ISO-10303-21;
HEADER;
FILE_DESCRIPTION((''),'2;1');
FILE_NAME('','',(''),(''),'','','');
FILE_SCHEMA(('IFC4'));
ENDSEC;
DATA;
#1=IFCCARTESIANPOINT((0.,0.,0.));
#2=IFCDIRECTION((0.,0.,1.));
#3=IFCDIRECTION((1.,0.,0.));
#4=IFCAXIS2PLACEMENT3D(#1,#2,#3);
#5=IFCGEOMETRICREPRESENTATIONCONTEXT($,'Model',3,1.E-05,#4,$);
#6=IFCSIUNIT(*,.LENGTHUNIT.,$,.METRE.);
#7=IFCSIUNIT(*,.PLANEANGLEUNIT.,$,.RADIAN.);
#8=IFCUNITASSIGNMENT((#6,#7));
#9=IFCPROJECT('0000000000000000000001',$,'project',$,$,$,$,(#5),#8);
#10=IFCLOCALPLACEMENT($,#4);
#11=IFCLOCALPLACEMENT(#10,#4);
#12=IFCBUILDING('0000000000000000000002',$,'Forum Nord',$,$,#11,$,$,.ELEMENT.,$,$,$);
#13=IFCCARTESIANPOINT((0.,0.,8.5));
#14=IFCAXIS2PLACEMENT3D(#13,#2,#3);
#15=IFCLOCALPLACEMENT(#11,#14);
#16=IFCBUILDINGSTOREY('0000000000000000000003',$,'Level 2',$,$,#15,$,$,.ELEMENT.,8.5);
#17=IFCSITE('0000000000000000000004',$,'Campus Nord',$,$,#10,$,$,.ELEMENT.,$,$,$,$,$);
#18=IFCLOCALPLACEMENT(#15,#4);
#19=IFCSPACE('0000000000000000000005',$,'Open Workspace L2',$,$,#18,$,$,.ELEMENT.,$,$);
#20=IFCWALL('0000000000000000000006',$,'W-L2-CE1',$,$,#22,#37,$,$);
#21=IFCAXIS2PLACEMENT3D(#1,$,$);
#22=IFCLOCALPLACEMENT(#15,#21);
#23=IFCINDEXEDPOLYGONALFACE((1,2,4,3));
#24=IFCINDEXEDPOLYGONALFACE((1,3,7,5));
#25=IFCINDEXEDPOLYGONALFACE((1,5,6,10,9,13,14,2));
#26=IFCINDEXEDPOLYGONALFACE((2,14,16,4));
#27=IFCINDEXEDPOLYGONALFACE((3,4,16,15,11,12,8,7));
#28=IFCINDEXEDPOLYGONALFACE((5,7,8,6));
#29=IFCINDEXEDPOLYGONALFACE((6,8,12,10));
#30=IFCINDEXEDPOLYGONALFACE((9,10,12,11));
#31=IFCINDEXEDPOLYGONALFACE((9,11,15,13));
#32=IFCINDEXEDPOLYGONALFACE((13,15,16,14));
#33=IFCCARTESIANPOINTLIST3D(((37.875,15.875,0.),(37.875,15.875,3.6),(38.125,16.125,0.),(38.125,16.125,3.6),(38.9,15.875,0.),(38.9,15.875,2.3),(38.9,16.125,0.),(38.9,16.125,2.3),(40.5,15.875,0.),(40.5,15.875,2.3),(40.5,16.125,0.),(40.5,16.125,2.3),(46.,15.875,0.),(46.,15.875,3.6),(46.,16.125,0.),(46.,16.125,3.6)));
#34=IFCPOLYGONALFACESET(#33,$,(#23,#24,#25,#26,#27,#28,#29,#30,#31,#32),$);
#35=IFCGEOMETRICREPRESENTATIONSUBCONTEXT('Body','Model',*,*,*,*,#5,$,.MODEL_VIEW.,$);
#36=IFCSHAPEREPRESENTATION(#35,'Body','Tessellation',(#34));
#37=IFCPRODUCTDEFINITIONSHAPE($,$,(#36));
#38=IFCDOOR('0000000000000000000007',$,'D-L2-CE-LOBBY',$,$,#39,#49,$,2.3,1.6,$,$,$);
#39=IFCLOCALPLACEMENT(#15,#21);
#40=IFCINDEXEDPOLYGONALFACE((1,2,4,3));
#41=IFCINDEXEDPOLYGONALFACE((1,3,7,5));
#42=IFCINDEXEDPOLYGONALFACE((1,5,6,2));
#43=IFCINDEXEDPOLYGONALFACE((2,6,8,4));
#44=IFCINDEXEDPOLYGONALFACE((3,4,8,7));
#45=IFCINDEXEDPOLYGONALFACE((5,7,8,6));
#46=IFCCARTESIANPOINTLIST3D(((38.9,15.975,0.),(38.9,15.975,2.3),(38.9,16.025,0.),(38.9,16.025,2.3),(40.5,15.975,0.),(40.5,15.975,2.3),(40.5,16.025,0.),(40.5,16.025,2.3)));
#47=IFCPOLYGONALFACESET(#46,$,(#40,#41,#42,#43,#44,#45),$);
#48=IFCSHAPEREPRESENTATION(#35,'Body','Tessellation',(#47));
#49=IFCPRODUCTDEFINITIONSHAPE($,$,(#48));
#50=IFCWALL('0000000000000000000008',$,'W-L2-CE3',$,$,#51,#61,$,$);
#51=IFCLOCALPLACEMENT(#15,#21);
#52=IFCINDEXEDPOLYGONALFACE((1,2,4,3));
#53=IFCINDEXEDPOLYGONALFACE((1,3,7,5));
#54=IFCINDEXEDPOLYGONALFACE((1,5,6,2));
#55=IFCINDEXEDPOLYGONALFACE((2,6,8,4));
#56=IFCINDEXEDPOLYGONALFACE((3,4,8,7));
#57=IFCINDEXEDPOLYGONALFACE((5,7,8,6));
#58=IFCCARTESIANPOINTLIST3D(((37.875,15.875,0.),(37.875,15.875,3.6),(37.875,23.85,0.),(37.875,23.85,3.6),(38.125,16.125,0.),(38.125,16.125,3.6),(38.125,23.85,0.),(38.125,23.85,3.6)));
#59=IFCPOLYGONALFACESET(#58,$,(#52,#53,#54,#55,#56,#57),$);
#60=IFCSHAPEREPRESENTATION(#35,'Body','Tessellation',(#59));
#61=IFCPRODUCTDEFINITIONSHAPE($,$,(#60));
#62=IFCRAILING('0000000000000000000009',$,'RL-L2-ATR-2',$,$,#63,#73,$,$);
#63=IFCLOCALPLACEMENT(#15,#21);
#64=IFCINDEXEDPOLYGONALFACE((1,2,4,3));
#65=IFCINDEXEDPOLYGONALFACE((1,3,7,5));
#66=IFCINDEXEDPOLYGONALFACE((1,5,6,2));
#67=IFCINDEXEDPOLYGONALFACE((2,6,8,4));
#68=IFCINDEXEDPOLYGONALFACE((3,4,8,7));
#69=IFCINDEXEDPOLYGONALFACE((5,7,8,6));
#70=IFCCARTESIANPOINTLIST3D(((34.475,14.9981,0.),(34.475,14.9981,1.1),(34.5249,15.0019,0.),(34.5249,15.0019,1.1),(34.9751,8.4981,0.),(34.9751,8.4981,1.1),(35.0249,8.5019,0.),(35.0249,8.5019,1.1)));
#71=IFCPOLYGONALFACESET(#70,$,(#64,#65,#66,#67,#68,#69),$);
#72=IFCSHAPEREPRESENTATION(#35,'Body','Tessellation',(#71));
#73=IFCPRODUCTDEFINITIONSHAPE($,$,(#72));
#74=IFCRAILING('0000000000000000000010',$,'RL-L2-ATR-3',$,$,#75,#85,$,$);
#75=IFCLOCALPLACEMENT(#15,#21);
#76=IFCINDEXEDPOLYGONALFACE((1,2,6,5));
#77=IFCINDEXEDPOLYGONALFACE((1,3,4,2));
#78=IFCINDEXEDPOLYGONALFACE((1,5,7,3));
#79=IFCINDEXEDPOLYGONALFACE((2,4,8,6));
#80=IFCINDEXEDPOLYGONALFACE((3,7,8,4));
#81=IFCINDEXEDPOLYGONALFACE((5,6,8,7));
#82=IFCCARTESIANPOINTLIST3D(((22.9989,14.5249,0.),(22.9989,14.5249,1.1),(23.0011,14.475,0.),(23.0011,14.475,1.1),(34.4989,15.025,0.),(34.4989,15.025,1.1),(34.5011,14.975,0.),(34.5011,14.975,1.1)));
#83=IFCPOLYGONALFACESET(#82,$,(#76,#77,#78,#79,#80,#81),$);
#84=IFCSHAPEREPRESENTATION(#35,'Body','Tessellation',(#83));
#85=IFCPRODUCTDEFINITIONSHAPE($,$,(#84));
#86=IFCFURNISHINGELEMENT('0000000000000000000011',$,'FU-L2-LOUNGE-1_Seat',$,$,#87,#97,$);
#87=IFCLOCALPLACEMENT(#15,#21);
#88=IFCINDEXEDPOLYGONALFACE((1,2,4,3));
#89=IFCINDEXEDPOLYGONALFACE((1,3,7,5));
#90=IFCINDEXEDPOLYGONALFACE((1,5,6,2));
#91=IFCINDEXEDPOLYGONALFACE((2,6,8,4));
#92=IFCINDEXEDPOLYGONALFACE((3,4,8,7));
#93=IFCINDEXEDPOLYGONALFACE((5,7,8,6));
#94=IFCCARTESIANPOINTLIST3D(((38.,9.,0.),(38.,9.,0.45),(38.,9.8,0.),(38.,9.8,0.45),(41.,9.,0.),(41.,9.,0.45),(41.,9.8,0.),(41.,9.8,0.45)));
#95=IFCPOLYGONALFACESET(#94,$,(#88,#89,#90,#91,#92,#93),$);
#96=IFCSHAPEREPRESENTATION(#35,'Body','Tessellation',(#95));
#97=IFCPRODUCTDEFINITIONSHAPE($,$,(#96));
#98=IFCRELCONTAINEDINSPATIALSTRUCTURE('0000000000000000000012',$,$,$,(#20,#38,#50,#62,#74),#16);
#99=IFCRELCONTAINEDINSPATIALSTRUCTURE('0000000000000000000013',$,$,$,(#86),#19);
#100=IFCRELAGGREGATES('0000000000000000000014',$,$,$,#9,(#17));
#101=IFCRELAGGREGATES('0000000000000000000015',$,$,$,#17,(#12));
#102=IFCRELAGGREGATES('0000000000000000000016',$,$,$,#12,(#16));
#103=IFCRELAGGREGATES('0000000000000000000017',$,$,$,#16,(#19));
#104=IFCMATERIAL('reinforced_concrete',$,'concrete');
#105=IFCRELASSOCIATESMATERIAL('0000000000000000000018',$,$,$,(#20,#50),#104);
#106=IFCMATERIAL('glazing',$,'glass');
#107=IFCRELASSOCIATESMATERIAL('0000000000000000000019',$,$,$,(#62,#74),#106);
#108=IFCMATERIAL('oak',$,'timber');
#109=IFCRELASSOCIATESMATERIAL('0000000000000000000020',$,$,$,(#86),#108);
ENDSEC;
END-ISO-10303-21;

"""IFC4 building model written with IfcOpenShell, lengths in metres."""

from ifc_helpers import new_model, si_unit, frame, frame_2d, origin_with_axes, place, context, subcontext, project, spatial, polyline, rectangle, outline, extrude, material, element, fill, save


model = new_model("IFC4")

# Units and contexts
model_context = context("Model", 3, precision=1e-05, world=origin_with_axes())
body_context = subcontext(model_context, "Body", "Model", "MODEL_VIEW")
ifc_project = project(units=[si_unit("LENGTHUNIT", "METRE"), si_unit("PLANEANGLEUNIT", "RADIAN")], contexts=[model_context])

# Site, building, storey
site_placement = place(None, origin_with_axes())
site = spatial("IfcSite", under=ifc_project, at=site_placement, Name="Campus Nord", CompositionType="ELEMENT")
building_placement = place(site_placement, origin_with_axes())
building = spatial("IfcBuilding", under=site, at=building_placement, Name="Forum Nord", CompositionType="ELEMENT")
storey_placement = place(building_placement, frame((0.0, 0.0, 8.5), z_axis=(0.0, 0.0, 1.0), x_axis=(1.0, 0.0, 0.0)))
storey = spatial("IfcBuildingStorey", under=building, at=storey_placement, Name="Level 2", CompositionType="ELEMENT", Elevation=8.5)

# Wall, opening, door
ifc_material_1 = material(Name="reinforced_concrete", Category="concrete")
wall_1_placement = place(storey_placement, frame((38.0, 16.0, 0.0), z_axis=(0.0, 0.0, 1.0), x_axis=(1.0, 0.0, 0.0)))
wall_1 = element("IfcWall", 1, at=wall_1_placement, inside=storey, material=ifc_material_1, Name="W-L2-CE1", context=body_context, shape_type="SweptSolid", body=[
    extrude(outline(polyline([(-0.125, -0.125), (8.0, -0.125), (8.0, 0.125), (0.125, 0.125), (-0.125, -0.125)])), origin_with_axes(), (0.0, 0.0, 1.0), 3.6),
])
opening_placement = place(storey_placement, frame((38.0, 16.0, 0.0), z_axis=(0.0, 0.0, 1.0), x_axis=(1.0, 0.0, 0.0)))
opening = element("IfcOpeningElement", 2, at=opening_placement, cuts=wall_1, context=body_context, shape_type="SweptSolid", body=[
    extrude(rectangle(XDim=1.6, YDim=0.25, at=frame_2d((1.7, 0.0), x_axis=(1.0, 0.0))), origin_with_axes(), (0.0, 0.0, 1.0), 2.3),
])
door_placement = place(storey_placement, frame((38.0, 16.0, 0.0), z_axis=(0.0, 0.0, 1.0), x_axis=(1.0, 0.0, 0.0)))
door = element("IfcDoor", 3, at=door_placement, inside=storey, Name="D-L2-CE-LOBBY", OverallHeight=2.3, OverallWidth=1.6, context=body_context, shape_type="SweptSolid", body=[
    extrude(rectangle(XDim=1.6, YDim=0.05, at=frame_2d((1.7, 0.0), x_axis=(1.0, 0.0))), origin_with_axes(), (0.0, 0.0, 1.0), 2.3),
])
fill(opening, door)

# Wall
wall_2_placement = place(storey_placement, frame((38.0, 16.0, 0.0), z_axis=(0.0, 0.0, 1.0), x_axis=(0.0, 1.0, 0.0)))
element("IfcWall", 4, at=wall_2_placement, inside=storey, material=ifc_material_1, Name="W-L2-CE3", context=body_context, shape_type="SweptSolid", body=[
    extrude(outline(polyline([(0.125, -0.125), (7.85, -0.125), (7.85, 0.125), (-0.125, 0.125), (0.125, -0.125)])), origin_with_axes(), (0.0, 0.0, 1.0), 3.6),
])

# Railings
ifc_material_2 = material(Name="glazing", Category="glass")
railing_1_placement = place(storey_placement, frame((35.0, 8.5, 0.0), z_axis=(0.0, 0.0, 1.0), x_axis=(-0.0767, 0.99705, 0.0)))
element("IfcRailing", 5, at=railing_1_placement, inside=storey, material=ifc_material_2, Name="RL-L2-ATR-2", context=body_context, shape_type="SweptSolid", body=[
    extrude(rectangle(XDim=6.5192, YDim=0.05, at=frame_2d((3.2596, 0.0), x_axis=(1.0, 0.0))), origin_with_axes(), (0.0, 0.0, 1.0), 1.1),
])
railing_2_placement = place(storey_placement, frame((34.5, 15.0, 0.0), z_axis=(0.0, 0.0, 1.0), x_axis=(-0.99906, -0.04344, 0.0)))
element("IfcRailing", 6, at=railing_2_placement, inside=storey, material=ifc_material_2, Name="RL-L2-ATR-3", context=body_context, shape_type="SweptSolid", body=[
    extrude(rectangle(XDim=11.5109, YDim=0.05, at=frame_2d((5.7554, 0.0), x_axis=(1.0, 0.0))), origin_with_axes(), (0.0, 0.0, 1.0), 1.1),
])

# Shared definitions
space_1_placement = place(storey_placement, origin_with_axes())
space_1 = spatial("IfcSpace", under=storey, at=space_1_placement, Name="Open Workspace L2", CompositionType="ELEMENT")

# Furnishing element
ifc_material_3 = material(Name="oak", Category="timber")
furnishing_1_placement = place(storey_placement, frame((38.0, 9.0, 0.0), z_axis=(0.0, 0.0, 1.0), x_axis=(1.0, 0.0, 0.0)))
element("IfcFurnishingElement", 7, at=furnishing_1_placement, inside=space_1, material=ifc_material_3, Name="FU-L2-LOUNGE-1_Seat", context=body_context, shape_type="SweptSolid", body=[
    extrude(rectangle(XDim=3.0, YDim=0.8, at=frame_2d((1.5, 0.4), x_axis=(1.0, 0.0))), origin_with_axes(), (0.0, 0.0, 1.0), 0.45),
])

save(model, "model.ifc")
